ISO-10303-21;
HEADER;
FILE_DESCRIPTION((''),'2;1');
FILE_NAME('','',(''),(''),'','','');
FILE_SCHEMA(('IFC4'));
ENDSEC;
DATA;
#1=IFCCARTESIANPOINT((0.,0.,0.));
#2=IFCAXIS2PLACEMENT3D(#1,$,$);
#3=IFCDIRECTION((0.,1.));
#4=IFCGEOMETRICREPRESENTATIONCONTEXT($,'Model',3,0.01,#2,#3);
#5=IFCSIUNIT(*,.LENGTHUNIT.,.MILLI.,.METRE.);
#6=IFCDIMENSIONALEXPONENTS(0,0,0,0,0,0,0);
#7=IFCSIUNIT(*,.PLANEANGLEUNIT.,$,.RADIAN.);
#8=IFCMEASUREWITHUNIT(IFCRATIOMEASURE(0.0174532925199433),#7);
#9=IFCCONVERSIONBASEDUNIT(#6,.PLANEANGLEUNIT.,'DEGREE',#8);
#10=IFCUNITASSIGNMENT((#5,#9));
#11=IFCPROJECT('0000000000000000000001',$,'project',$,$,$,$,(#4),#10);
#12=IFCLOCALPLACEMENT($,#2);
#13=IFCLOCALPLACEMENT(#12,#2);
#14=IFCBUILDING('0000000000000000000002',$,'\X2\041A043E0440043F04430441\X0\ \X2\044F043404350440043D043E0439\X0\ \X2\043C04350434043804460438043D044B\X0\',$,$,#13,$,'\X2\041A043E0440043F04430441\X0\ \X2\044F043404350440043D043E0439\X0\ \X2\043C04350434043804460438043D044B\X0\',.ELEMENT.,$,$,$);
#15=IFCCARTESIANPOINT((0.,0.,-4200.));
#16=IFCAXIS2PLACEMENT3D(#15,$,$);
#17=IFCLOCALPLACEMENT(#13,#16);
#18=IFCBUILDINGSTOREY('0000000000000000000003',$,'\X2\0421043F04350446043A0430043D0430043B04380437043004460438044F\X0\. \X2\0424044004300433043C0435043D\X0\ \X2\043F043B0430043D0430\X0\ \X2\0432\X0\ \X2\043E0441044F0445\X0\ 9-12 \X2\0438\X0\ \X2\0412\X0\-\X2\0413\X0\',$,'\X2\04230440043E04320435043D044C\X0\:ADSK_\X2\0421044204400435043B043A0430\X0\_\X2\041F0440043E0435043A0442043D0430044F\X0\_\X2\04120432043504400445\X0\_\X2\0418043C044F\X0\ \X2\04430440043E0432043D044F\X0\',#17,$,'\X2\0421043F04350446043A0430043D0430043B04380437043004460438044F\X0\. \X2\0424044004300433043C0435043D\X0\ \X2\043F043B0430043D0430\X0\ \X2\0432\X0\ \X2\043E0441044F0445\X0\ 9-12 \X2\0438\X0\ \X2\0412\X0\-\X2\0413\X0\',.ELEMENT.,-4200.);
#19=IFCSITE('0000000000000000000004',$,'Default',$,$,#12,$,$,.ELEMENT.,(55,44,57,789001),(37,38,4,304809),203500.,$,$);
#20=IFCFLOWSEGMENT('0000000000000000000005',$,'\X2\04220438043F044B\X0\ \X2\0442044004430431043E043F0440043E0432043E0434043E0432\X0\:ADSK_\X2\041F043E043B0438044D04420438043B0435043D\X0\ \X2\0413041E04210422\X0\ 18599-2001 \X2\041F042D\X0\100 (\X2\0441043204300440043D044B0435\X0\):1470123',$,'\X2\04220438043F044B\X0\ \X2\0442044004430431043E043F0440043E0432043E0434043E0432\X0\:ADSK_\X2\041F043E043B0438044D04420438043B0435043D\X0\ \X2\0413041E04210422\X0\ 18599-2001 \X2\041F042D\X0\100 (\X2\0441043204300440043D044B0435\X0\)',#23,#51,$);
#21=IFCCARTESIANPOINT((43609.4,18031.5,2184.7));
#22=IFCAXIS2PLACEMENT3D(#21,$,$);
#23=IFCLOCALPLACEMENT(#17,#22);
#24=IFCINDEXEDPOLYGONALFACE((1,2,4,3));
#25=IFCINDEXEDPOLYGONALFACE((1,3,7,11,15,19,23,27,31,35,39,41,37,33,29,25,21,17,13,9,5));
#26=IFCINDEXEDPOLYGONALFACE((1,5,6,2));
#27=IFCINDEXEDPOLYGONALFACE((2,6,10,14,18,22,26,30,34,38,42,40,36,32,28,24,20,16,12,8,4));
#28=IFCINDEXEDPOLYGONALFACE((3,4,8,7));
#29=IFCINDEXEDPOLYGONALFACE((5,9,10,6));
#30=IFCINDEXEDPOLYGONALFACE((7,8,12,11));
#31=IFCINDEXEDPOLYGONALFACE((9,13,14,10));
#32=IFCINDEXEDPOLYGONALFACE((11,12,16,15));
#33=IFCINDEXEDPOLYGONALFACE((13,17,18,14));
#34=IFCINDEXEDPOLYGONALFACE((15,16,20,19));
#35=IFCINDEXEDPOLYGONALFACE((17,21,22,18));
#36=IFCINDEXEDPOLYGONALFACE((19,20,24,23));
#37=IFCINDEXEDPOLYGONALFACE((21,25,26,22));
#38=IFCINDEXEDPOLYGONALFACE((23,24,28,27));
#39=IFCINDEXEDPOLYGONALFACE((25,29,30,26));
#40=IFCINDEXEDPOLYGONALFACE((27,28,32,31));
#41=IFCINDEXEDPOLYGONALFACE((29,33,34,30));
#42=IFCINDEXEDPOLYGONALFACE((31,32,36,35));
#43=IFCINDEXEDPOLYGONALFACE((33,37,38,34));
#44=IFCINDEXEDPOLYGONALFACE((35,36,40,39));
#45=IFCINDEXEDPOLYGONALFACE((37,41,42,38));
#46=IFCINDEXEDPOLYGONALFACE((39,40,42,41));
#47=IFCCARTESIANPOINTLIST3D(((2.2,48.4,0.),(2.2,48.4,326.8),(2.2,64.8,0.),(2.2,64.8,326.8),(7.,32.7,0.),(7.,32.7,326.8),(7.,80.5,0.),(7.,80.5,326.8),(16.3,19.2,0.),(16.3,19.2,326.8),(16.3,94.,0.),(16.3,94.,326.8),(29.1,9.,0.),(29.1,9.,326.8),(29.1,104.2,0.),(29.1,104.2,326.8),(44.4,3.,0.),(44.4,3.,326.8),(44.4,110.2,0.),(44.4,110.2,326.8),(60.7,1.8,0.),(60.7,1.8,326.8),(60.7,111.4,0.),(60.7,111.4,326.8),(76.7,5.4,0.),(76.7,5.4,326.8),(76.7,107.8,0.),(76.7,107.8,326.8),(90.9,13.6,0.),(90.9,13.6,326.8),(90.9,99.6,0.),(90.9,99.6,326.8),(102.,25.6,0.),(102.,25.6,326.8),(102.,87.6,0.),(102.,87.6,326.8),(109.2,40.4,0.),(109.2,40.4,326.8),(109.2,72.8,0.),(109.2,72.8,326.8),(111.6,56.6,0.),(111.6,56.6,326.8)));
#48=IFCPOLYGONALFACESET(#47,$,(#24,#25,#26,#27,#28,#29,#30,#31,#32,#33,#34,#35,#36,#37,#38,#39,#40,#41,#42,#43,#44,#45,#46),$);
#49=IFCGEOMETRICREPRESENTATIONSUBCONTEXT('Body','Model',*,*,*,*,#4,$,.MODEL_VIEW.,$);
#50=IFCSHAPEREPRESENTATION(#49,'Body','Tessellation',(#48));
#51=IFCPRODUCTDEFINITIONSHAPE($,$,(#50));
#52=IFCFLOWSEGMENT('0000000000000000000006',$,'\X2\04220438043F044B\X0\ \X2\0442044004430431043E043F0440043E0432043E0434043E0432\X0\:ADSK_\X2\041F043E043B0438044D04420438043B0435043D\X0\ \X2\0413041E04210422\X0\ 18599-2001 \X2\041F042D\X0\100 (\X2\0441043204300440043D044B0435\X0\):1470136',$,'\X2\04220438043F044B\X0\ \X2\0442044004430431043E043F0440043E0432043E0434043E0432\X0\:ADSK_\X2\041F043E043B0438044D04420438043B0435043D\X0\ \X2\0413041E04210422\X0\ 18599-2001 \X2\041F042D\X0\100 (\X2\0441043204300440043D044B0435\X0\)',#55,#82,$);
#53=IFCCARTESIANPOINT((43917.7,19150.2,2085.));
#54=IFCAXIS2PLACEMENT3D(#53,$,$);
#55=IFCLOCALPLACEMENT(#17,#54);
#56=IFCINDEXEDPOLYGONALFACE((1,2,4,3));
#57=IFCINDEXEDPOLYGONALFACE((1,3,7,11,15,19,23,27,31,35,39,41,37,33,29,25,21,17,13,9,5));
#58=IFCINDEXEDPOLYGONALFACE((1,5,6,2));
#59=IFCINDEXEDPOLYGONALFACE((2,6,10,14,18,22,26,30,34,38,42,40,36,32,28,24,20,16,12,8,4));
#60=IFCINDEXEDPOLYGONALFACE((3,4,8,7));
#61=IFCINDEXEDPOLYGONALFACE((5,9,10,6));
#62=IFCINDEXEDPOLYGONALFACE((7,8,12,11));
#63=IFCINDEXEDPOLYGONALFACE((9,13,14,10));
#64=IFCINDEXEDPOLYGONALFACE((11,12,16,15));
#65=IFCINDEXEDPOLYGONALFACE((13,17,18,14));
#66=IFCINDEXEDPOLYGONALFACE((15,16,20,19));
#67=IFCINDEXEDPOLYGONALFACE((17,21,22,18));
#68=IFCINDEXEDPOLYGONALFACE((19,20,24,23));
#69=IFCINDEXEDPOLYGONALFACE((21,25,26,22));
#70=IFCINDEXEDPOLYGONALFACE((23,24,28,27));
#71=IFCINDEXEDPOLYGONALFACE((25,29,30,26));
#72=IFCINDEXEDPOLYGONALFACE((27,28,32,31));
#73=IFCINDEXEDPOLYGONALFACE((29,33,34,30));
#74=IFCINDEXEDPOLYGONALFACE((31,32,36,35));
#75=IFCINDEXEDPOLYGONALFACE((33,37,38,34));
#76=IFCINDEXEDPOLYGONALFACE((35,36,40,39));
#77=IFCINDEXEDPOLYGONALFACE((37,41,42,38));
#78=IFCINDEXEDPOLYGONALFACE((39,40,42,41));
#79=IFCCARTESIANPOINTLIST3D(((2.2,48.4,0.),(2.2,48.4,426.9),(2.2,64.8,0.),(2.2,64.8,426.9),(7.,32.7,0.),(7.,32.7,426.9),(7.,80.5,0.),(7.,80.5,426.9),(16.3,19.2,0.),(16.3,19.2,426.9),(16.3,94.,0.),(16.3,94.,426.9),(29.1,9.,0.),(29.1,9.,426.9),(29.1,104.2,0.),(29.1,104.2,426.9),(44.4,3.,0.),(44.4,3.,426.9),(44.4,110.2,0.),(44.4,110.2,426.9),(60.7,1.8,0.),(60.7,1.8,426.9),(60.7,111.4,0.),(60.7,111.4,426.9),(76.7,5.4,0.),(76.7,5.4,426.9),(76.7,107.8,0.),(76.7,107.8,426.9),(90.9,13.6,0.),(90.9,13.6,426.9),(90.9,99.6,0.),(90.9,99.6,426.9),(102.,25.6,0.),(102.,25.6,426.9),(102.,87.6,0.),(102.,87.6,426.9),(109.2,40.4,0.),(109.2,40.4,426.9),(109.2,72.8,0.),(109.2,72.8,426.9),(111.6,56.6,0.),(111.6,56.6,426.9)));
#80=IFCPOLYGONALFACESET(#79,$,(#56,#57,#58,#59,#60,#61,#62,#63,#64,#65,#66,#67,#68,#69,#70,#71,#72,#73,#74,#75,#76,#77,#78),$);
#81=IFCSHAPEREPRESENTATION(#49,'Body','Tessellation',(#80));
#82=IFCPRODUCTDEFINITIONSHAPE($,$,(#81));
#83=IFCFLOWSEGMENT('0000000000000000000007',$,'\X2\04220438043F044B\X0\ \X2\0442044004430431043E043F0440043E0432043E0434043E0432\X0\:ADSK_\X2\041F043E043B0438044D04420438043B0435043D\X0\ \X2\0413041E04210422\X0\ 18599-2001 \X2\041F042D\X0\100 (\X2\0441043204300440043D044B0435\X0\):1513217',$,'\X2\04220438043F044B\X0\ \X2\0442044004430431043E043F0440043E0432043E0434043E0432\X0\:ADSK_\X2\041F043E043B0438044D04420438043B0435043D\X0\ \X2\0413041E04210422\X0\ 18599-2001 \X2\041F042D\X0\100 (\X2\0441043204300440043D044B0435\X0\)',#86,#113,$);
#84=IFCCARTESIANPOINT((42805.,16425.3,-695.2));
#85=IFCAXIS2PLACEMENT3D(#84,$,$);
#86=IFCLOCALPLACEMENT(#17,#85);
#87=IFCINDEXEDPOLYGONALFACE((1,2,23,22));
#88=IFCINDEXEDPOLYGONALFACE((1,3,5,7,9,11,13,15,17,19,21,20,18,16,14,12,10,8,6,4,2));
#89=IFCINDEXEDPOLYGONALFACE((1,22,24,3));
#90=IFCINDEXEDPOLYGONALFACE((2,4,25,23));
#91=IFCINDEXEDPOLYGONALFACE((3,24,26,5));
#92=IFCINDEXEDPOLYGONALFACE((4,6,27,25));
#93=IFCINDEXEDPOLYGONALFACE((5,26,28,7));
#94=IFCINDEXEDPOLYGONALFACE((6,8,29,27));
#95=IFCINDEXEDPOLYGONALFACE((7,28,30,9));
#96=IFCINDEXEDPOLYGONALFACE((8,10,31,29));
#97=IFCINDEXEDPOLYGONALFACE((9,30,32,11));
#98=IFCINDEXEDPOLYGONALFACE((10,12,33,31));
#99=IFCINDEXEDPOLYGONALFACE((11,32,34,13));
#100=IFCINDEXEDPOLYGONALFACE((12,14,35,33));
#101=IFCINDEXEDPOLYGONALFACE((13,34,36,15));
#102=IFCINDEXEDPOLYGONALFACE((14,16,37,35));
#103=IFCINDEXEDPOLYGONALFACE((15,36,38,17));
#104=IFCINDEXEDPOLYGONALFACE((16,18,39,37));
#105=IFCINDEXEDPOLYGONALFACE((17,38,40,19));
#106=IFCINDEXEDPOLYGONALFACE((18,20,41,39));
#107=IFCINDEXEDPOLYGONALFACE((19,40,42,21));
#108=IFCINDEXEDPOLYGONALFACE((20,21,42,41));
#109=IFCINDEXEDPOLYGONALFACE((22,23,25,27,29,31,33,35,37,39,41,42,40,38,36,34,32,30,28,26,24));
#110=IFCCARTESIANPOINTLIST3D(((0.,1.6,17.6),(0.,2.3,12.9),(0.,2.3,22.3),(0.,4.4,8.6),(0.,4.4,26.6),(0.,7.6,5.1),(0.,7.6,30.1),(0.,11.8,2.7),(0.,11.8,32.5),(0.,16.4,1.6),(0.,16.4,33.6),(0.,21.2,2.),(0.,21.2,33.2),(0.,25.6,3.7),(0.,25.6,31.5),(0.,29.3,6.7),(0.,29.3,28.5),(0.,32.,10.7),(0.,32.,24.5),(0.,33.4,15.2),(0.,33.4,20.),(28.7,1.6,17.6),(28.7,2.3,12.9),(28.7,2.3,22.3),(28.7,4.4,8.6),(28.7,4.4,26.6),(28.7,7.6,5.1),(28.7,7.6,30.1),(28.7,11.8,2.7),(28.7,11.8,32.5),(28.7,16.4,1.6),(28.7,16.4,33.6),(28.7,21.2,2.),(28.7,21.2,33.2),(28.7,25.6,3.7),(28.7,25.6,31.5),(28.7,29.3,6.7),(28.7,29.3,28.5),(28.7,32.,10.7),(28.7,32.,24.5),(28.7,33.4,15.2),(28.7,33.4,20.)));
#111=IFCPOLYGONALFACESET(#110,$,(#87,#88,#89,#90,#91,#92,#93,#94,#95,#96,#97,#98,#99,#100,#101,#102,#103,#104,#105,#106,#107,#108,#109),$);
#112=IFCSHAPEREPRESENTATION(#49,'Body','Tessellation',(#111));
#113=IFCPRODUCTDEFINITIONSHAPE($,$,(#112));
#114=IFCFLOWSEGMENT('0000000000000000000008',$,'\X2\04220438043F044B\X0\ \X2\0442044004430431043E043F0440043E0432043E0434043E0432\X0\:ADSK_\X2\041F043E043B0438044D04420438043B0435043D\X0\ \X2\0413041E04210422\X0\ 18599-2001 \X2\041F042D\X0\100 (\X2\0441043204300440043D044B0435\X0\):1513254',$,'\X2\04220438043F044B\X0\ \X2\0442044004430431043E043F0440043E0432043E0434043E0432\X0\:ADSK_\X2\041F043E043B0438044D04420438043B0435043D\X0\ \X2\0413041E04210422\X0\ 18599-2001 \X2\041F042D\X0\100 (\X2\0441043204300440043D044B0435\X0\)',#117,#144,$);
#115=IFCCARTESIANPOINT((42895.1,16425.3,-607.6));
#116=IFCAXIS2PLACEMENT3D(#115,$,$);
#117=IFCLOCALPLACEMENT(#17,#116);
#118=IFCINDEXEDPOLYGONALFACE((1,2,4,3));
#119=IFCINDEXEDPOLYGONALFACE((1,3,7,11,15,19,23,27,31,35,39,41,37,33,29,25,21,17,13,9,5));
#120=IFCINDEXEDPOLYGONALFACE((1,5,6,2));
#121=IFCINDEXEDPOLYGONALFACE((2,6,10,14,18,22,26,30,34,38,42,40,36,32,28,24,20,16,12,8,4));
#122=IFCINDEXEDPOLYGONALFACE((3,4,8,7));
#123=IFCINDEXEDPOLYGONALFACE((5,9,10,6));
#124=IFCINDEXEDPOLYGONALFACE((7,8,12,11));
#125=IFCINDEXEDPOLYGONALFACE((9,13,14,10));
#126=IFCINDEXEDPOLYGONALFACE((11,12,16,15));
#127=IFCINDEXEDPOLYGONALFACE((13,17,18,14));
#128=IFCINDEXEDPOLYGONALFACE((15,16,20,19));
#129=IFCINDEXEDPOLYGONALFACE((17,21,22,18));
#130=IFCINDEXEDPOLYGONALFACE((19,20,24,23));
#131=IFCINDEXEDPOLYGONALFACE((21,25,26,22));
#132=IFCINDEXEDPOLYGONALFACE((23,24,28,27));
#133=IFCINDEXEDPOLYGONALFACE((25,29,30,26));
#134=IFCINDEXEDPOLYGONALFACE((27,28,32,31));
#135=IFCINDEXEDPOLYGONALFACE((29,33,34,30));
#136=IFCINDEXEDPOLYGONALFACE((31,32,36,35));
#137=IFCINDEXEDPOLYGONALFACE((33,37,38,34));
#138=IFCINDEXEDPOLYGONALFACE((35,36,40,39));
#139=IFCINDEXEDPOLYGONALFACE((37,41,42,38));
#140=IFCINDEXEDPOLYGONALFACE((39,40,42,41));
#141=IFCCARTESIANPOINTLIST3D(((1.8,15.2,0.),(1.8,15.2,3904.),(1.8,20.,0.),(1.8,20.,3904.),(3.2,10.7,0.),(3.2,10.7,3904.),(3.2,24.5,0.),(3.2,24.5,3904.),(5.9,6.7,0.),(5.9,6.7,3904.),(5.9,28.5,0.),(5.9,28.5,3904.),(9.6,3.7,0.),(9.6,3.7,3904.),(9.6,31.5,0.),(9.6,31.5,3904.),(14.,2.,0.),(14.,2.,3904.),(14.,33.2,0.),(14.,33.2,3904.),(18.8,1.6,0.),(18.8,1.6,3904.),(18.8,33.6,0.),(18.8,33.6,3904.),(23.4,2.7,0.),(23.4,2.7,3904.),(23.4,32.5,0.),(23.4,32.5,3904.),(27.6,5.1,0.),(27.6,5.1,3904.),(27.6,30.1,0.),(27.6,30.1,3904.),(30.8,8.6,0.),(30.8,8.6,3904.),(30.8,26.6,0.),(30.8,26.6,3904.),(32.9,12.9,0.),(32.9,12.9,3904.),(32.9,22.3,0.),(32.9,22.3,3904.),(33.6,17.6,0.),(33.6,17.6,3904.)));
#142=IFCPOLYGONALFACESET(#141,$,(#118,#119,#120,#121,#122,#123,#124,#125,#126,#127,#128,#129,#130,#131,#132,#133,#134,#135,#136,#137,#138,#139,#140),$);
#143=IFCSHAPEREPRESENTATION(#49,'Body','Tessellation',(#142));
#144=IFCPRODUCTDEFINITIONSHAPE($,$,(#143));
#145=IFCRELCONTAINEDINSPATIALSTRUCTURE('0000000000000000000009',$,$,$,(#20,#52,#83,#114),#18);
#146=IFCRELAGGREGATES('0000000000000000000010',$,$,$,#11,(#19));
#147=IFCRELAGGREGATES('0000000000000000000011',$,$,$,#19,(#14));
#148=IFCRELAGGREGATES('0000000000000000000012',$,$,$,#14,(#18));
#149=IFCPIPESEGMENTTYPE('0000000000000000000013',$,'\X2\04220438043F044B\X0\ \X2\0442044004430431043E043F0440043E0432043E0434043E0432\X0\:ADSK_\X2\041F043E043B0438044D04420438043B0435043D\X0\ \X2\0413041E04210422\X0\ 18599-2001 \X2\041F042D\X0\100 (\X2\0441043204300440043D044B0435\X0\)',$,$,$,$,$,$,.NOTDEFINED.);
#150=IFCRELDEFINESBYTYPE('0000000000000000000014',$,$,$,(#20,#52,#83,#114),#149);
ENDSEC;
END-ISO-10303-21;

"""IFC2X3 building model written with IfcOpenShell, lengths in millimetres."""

from ifc_helpers import new_model, entity, si_unit, converted_unit, direction, frame, origin, origin_2d_with_axis, place, context, subcontext, project, spatial, circle, extrude, type_object, element, save


model = new_model("IFC2X3")

# Units and contexts
model_context = context("Model", 3, precision=0.01, world=origin(), true_north=direction((0.0, 1.0)))
body_context = subcontext(model_context, "Body", "Model", "MODEL_VIEW")
ifc_project = project(units=[si_unit("LENGTHUNIT", "METRE", prefix="MILLI"), converted_unit("PLANEANGLEUNIT", "DEGREE", entity("IfcRatioMeasure", 0.0174532925199433), si_unit("PLANEANGLEUNIT", "RADIAN"), dimensions=[0, 0, 0, 0, 0, 0, 0])], contexts=[model_context])

# Site, building, storey
site_placement = place(None, origin())
site = spatial("IfcSite", under=ifc_project, at=site_placement, Name="Default", CompositionType="ELEMENT", RefLatitude=(55, 44, 57, 789001), RefLongitude=(37, 38, 4, 304809), RefElevation=203500.0)
building_placement = place(site_placement, origin())
building = spatial("IfcBuilding", under=site, at=building_placement, Name="Корпус ядерной медицины", LongName="Корпус ядерной медицины", CompositionType="ELEMENT")
storey_placement = place(building_placement, frame((0.0, 0.0, -4200.0)))
storey = spatial("IfcBuildingStorey", under=building, at=storey_placement, Name="Спецканализация. Фрагмен плана в осях 9-12 и В-Г", ObjectType="Уровень:ADSK_Стрелка_Проектная_Вверх_Имя уровня", LongName="Спецканализация. Фрагмен плана в осях 9-12 и В-Г", CompositionType="ELEMENT", Elevation=-4200.0)

# Flow segments
pipe_segment_type = type_object("IfcPipeSegmentType", Name="Типы трубопроводов:ADSK_Полиэтилен ГОСТ 18599-2001 ПЭ100 (сварные)", PredefinedType="NOTDEFINED")
flow_segment_1_placement = place(storey_placement, frame((43609.4, 18031.5, 2184.7)))
element("IfcFlowSegment", 1, at=flow_segment_1_placement, inside=storey, type_object=pipe_segment_type, Name="Типы трубопроводов:ADSK_Полиэтилен ГОСТ 18599-2001 ПЭ100 (сварные):1470123", ObjectType="Типы трубопроводов:ADSK_Полиэтилен ГОСТ 18599-2001 ПЭ100 (сварные)", context=body_context, shape_type="SweptSolid", body=[
    extrude(circle(Radius=55.0, at=origin_2d_with_axis()), frame((56.6, 56.6, 0.0)), (0.0, 0.0, 1.0), 326.8),
])
flow_segment_2_placement = place(storey_placement, frame((43917.7, 19150.2, 2085.0)))
element("IfcFlowSegment", 2, at=flow_segment_2_placement, inside=storey, type_object=pipe_segment_type, Name="Типы трубопроводов:ADSK_Полиэтилен ГОСТ 18599-2001 ПЭ100 (сварные):1470136", ObjectType="Типы трубопроводов:ADSK_Полиэтилен ГОСТ 18599-2001 ПЭ100 (сварные)", context=body_context, shape_type="SweptSolid", body=[
    extrude(circle(Radius=55.0, at=origin_2d_with_axis()), frame((56.6, 56.6, 0.0)), (0.0, 0.0, 1.0), 426.9),
])
flow_segment_3_placement = place(storey_placement, frame((42805.0, 16425.3, -695.2)))
element("IfcFlowSegment", 3, at=flow_segment_3_placement, inside=storey, type_object=pipe_segment_type, Name="Типы трубопроводов:ADSK_Полиэтилен ГОСТ 18599-2001 ПЭ100 (сварные):1513217", ObjectType="Типы трубопроводов:ADSK_Полиэтилен ГОСТ 18599-2001 ПЭ100 (сварные)", context=body_context, shape_type="SweptSolid", body=[
    extrude(circle(Radius=16.0, at=origin_2d_with_axis()), frame((0.0, 17.6, 17.6), z_axis=(1.0, 0.0, 0.0), x_axis=(0.0, -1.0, 0.0)), (0.0, 0.0, 1.0), 28.7),
])
flow_segment_4_placement = place(storey_placement, frame((42895.1, 16425.3, -607.6)))
element("IfcFlowSegment", 4, at=flow_segment_4_placement, inside=storey, type_object=pipe_segment_type, Name="Типы трубопроводов:ADSK_Полиэтилен ГОСТ 18599-2001 ПЭ100 (сварные):1513254", ObjectType="Типы трубопроводов:ADSK_Полиэтилен ГОСТ 18599-2001 ПЭ100 (сварные)", context=body_context, shape_type="SweptSolid", body=[
    extrude(circle(Radius=16.0, at=origin_2d_with_axis()), frame((17.6, 17.6, 0.0)), (0.0, 0.0, 1.0), 3904.0),
])

save(model, "model.ifc")
